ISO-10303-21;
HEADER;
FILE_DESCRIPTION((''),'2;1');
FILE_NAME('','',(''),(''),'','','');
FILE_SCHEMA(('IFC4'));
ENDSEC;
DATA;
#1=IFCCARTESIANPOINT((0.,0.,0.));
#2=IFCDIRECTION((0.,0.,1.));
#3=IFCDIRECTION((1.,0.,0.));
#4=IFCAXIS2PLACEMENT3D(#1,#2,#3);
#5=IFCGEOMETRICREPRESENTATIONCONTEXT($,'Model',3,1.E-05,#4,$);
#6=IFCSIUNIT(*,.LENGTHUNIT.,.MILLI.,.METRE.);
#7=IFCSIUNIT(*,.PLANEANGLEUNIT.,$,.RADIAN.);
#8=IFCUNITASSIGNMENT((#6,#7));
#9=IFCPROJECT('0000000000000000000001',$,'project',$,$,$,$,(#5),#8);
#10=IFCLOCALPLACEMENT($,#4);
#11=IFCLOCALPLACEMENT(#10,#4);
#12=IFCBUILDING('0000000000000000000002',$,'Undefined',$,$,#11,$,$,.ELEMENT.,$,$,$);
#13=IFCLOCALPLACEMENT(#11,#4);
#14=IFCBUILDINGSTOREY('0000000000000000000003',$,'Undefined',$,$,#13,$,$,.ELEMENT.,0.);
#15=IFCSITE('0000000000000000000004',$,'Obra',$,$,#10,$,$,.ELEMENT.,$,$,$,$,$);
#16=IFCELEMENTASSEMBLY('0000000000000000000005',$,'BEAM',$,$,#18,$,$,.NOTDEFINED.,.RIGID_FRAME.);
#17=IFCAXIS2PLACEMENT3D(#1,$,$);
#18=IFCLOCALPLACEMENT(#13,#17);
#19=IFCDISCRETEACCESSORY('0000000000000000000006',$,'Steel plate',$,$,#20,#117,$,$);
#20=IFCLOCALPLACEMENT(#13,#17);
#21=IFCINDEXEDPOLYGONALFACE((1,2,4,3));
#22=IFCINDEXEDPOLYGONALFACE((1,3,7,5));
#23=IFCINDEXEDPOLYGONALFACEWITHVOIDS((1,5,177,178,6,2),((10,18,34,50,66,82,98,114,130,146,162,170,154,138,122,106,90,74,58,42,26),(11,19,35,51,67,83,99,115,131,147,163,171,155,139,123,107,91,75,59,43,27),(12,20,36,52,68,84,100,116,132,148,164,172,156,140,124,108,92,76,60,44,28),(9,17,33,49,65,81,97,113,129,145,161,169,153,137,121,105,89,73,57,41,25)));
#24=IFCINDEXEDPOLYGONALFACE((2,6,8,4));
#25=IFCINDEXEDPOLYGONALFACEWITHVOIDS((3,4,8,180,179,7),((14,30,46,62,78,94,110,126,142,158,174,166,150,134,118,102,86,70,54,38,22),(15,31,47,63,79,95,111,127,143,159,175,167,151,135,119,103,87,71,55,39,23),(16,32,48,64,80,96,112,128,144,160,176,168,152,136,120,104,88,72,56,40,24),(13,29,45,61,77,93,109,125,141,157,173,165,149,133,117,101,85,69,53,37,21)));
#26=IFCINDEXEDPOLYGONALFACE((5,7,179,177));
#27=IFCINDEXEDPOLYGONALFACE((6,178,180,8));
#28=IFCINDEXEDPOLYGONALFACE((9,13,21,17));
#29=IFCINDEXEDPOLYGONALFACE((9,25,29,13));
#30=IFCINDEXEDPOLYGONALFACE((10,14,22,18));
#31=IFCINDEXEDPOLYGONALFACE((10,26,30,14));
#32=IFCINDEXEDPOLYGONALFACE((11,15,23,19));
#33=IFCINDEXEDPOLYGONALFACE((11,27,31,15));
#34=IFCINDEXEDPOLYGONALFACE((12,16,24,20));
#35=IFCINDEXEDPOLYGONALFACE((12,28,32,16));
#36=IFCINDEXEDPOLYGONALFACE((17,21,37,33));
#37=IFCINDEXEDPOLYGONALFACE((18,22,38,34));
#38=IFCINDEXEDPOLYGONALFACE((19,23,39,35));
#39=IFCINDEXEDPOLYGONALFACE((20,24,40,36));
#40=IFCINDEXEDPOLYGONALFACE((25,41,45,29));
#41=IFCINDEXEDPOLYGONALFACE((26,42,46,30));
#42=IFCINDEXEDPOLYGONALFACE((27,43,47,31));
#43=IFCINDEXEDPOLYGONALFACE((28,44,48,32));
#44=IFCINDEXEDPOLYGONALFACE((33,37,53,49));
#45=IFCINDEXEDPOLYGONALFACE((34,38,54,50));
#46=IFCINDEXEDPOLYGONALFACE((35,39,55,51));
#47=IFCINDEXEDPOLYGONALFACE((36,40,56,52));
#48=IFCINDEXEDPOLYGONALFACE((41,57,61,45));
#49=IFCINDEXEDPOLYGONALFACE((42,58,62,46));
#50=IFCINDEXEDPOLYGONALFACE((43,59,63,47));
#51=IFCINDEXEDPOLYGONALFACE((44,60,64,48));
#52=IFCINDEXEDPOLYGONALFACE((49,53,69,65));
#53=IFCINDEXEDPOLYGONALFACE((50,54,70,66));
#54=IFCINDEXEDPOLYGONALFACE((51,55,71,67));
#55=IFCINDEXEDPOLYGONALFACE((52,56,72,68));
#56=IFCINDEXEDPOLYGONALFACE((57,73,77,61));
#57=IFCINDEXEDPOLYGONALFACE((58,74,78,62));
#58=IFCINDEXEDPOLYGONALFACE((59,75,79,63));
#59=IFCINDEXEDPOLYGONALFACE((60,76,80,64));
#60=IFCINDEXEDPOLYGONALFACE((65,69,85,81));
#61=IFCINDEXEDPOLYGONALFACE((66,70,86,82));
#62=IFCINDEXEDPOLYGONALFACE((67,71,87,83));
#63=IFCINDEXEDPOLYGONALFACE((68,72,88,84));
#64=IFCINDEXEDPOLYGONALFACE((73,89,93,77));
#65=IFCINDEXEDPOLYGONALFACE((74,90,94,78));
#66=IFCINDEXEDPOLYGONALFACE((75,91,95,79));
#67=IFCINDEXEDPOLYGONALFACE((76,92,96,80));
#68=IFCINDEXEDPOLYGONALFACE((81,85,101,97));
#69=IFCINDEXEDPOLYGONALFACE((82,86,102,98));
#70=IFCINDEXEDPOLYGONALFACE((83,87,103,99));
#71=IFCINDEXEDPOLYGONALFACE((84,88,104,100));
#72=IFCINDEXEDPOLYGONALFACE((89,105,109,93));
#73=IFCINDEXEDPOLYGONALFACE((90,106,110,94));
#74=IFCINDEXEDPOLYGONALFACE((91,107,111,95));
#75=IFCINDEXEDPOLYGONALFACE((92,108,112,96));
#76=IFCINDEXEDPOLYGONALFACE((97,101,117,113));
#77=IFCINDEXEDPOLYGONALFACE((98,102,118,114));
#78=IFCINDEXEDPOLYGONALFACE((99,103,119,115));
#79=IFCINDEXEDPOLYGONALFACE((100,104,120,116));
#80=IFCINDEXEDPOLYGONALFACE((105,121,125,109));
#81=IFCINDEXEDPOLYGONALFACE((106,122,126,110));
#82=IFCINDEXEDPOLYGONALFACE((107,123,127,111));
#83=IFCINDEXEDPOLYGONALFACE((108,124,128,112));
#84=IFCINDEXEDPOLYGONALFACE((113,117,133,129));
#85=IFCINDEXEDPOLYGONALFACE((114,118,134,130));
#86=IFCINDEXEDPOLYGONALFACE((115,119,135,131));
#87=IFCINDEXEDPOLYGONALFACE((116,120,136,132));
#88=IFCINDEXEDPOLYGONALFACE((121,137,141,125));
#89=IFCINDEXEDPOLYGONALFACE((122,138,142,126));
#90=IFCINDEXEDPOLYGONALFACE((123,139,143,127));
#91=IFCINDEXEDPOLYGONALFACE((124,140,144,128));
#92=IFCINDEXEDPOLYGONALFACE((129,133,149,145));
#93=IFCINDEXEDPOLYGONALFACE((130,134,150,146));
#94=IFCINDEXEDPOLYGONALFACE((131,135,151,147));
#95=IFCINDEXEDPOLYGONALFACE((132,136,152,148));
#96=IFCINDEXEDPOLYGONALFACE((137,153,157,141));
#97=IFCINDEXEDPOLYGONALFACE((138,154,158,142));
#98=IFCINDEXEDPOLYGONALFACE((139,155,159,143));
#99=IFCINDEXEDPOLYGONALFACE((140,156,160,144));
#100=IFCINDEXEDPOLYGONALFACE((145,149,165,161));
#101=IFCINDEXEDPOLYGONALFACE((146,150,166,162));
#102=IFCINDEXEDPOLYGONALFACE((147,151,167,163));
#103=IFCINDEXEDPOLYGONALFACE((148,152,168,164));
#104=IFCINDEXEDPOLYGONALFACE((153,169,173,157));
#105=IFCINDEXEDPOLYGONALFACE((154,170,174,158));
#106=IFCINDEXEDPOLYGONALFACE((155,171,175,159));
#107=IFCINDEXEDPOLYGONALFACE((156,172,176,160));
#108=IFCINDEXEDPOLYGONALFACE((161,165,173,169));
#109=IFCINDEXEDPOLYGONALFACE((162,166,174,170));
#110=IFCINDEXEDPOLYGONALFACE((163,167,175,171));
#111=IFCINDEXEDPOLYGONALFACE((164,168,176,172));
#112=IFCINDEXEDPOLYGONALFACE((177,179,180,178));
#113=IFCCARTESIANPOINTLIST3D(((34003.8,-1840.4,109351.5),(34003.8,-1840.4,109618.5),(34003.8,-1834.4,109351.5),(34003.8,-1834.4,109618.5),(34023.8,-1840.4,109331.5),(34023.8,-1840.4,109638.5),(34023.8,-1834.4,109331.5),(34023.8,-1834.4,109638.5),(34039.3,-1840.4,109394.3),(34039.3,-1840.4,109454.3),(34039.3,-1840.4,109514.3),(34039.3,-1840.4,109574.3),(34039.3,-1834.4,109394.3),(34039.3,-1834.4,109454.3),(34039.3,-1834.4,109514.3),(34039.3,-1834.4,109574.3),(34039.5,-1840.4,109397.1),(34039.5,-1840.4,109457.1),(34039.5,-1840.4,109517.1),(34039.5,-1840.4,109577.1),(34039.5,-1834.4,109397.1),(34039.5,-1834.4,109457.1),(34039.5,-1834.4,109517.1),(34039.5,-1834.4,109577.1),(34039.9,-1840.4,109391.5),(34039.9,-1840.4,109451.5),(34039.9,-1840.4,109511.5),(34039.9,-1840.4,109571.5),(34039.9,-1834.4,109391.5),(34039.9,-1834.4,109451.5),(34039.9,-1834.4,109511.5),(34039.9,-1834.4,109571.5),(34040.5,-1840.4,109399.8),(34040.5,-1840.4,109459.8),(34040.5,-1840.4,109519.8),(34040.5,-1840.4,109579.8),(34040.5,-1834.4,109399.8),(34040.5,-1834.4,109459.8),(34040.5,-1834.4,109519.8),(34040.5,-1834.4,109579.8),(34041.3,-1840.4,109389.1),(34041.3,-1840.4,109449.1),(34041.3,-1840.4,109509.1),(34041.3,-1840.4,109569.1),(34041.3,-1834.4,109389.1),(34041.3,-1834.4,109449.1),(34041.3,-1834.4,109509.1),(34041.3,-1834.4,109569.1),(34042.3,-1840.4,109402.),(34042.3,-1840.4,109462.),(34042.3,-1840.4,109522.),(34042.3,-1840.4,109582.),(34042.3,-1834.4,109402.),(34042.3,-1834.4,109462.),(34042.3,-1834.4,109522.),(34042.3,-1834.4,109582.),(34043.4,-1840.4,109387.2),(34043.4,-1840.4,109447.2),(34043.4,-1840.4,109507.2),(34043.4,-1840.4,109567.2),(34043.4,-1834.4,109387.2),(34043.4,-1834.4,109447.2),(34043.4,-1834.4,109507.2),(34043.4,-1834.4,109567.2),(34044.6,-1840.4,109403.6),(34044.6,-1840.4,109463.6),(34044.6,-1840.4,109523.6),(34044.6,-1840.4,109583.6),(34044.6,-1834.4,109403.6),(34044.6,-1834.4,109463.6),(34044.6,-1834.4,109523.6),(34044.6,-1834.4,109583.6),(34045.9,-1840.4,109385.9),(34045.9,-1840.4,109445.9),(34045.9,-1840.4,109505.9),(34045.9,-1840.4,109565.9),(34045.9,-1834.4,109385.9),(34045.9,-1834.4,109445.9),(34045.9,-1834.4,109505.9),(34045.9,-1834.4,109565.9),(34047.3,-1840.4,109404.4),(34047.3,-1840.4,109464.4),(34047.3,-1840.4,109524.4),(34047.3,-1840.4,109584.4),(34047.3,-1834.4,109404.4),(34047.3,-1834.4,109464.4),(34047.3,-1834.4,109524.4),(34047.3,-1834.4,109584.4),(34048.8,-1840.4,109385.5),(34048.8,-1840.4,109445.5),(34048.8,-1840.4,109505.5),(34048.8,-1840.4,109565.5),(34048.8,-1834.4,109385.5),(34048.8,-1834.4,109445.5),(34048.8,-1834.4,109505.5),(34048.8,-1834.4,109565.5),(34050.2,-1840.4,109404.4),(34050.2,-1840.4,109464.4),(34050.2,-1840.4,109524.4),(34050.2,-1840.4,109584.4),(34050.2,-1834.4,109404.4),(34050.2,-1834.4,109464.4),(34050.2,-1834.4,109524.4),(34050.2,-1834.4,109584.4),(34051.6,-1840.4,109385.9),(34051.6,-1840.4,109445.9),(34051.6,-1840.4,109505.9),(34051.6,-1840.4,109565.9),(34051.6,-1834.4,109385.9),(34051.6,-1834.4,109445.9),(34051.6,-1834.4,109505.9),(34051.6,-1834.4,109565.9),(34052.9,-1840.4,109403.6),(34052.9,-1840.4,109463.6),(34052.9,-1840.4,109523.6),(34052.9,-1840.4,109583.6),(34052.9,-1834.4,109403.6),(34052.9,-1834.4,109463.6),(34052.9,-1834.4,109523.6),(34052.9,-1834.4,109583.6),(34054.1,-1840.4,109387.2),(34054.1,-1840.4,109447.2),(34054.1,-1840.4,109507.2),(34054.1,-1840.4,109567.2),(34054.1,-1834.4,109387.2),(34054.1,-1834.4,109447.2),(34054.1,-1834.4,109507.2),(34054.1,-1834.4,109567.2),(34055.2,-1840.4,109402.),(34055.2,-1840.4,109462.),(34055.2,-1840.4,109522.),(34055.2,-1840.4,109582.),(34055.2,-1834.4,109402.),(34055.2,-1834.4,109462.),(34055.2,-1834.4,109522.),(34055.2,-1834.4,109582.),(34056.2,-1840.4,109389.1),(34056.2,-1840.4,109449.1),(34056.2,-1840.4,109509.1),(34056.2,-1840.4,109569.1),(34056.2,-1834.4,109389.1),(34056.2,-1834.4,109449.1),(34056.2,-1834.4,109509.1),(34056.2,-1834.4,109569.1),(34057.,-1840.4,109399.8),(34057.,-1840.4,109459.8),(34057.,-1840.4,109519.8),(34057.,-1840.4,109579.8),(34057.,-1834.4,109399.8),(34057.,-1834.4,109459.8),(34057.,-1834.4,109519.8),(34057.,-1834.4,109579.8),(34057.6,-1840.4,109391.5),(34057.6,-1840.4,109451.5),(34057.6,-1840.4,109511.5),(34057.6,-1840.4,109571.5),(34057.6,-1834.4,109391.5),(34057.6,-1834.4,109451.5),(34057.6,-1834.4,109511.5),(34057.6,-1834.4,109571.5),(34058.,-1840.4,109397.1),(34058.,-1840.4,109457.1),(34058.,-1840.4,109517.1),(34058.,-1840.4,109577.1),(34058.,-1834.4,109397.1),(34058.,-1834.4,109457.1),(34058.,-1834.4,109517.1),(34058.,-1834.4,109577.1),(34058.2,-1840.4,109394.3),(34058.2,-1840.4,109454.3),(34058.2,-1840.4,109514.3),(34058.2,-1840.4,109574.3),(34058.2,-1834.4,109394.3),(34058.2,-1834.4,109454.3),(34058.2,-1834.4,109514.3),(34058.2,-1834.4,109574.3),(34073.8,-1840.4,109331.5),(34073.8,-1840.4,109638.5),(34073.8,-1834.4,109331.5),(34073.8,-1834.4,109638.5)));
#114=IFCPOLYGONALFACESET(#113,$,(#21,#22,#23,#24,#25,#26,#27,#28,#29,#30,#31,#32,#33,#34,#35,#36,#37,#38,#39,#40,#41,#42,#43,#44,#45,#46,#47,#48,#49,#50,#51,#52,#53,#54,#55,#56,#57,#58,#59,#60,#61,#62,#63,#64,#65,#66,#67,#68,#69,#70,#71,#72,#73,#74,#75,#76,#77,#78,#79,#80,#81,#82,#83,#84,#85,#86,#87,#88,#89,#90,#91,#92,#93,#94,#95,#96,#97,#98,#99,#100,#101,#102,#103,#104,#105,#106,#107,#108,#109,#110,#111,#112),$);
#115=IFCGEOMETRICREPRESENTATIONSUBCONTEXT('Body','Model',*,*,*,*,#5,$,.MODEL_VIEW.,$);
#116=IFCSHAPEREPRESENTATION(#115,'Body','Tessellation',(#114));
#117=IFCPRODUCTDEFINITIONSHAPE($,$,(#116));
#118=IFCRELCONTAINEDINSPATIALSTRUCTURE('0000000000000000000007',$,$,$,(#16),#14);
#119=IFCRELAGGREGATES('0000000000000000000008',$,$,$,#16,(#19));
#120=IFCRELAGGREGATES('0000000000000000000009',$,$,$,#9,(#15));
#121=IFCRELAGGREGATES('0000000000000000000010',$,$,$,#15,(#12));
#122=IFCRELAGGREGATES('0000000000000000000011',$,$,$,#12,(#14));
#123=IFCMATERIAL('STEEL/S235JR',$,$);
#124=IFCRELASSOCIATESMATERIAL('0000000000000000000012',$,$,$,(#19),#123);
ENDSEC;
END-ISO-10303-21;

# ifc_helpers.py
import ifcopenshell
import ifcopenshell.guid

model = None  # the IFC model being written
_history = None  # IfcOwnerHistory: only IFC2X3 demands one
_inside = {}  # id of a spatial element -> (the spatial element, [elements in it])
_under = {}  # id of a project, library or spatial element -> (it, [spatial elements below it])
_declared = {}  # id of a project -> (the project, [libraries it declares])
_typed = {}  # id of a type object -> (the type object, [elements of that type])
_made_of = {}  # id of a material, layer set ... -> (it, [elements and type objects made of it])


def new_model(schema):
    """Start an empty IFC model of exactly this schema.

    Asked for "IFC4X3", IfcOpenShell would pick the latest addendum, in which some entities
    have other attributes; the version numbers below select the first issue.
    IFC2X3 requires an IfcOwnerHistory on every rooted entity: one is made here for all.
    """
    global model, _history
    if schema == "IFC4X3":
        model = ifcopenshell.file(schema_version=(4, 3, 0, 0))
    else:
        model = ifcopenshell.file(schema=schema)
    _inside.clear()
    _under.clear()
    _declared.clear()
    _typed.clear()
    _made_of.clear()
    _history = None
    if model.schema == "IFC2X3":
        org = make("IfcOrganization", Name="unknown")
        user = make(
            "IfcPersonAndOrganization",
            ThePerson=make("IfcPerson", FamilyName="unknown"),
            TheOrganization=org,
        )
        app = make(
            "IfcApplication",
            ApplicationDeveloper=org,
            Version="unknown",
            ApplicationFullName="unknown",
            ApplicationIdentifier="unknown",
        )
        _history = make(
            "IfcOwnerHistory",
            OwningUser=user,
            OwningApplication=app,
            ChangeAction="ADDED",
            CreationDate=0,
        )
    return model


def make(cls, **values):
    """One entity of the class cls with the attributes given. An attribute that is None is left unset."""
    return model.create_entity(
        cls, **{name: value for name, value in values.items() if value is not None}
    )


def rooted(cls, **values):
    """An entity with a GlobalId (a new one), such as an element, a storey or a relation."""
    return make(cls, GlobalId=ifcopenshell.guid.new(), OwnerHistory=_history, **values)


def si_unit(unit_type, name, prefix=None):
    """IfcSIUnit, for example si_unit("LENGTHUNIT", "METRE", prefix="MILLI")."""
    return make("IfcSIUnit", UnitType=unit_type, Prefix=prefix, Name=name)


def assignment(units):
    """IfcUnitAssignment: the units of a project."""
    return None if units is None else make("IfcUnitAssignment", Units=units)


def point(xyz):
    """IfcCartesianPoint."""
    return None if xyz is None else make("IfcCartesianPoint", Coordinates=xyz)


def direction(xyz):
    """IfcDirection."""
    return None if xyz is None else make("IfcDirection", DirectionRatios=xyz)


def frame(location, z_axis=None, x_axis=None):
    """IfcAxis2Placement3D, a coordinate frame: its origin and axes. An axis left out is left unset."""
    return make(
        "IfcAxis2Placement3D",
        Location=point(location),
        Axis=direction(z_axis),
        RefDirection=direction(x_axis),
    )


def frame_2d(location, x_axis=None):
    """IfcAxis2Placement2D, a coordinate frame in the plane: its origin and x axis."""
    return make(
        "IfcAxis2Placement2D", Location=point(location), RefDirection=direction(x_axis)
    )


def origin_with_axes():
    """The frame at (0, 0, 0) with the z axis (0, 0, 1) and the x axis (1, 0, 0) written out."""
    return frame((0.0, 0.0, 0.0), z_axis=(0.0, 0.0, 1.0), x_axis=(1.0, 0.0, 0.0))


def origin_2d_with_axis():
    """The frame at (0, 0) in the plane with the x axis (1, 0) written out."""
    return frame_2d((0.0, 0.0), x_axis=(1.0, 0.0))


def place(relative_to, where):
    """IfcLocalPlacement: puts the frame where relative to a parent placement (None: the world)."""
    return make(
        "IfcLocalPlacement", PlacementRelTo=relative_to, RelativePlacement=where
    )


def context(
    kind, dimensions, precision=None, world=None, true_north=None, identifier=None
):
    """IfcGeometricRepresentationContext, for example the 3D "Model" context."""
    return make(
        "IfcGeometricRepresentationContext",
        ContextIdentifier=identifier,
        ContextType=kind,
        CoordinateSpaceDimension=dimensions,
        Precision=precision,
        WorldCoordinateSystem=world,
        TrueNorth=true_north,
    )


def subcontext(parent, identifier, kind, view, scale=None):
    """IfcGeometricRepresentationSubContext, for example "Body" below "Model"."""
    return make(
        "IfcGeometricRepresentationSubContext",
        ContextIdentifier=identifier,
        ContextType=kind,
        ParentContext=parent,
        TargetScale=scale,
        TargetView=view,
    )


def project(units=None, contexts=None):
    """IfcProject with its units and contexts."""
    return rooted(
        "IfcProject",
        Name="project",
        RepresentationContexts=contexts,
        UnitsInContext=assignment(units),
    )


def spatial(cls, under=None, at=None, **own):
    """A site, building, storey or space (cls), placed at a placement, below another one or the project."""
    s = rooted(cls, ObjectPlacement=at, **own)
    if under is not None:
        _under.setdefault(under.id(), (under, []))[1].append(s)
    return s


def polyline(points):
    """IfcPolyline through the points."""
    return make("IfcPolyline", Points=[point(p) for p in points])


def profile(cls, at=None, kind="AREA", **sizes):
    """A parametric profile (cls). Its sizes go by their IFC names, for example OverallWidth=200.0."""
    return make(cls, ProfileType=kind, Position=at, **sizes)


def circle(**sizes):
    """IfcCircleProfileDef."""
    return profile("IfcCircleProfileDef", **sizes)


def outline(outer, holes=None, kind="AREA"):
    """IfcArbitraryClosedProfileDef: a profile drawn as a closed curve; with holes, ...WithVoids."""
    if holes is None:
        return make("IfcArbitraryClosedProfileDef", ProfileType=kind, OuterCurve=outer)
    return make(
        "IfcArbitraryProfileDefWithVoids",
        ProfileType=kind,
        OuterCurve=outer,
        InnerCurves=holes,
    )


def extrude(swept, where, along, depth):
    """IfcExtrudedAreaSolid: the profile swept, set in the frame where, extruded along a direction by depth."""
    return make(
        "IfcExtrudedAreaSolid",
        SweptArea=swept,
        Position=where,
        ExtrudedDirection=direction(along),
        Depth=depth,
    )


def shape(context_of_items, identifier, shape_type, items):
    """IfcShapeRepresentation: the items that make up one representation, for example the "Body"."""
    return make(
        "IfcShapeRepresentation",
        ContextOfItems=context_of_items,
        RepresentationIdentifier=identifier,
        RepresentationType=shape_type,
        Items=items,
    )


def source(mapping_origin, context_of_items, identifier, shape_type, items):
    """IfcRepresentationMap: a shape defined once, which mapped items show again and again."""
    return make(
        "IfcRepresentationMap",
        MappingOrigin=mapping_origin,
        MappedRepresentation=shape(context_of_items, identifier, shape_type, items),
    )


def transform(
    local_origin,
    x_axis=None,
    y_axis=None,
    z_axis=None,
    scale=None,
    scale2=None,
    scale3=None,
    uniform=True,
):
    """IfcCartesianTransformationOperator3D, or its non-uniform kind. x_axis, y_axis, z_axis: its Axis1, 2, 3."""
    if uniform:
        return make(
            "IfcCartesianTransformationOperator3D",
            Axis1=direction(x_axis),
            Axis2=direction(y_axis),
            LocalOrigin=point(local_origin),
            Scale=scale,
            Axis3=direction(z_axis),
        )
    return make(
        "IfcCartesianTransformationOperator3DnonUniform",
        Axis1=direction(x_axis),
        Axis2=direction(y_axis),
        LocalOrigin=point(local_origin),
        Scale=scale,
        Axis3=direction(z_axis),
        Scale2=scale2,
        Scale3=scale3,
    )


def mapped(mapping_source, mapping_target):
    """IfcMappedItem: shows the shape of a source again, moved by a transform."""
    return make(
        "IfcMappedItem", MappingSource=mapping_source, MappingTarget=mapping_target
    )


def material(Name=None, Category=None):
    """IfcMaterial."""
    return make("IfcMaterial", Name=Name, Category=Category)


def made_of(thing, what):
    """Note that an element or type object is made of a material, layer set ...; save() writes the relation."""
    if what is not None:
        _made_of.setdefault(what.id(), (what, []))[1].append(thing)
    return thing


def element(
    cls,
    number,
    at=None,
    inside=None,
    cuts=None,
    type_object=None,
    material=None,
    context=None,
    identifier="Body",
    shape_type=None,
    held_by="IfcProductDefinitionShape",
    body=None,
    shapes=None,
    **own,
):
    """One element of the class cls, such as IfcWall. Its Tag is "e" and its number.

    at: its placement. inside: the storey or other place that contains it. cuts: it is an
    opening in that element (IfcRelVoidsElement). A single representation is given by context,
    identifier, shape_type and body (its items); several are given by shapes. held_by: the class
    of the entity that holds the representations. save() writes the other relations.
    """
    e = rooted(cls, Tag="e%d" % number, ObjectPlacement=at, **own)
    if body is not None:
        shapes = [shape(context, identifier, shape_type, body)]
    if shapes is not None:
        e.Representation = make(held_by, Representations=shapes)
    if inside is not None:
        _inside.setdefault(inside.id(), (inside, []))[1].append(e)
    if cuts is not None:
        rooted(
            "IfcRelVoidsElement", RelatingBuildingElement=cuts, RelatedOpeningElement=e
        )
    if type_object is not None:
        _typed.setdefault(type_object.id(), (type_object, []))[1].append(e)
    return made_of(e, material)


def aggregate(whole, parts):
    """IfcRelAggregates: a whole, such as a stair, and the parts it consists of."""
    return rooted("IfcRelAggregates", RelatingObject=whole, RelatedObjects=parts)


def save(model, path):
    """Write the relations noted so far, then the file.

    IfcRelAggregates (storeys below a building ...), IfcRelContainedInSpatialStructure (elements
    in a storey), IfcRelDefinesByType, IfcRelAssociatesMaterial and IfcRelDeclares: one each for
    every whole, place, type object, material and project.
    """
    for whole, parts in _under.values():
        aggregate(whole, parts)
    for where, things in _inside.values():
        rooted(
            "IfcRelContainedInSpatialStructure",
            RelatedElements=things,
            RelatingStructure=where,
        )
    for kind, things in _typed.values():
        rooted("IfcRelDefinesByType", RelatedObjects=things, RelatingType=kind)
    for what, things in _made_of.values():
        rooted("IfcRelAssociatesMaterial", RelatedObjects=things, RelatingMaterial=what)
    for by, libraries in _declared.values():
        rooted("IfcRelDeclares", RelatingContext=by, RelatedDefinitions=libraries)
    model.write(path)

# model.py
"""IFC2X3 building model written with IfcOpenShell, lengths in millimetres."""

from ifc_helpers import new_model, si_unit, frame, origin_with_axes, origin_2d_with_axis, place, context, subcontext, project, spatial, polyline, circle, outline, extrude, source, transform, mapped, material, element, aggregate, save


model = new_model("IFC2X3")

# Units and contexts
model_context = context("Model", 3, precision=1e-05, world=origin_with_axes())
body_context = subcontext(model_context, "Body", "Model", "MODEL_VIEW")
ifc_project = project(units=[si_unit("LENGTHUNIT", "METRE", prefix="MILLI"), si_unit("PLANEANGLEUNIT", "RADIAN")], contexts=[model_context])

# Site, building, storey
site_placement = place(None, origin_with_axes())
site = spatial("IfcSite", under=ifc_project, at=site_placement, Name="Obra", CompositionType="ELEMENT")
building_placement = place(site_placement, origin_with_axes())
building = spatial("IfcBuilding", under=site, at=building_placement, Name="Undefined", CompositionType="ELEMENT")
storey_placement = place(building_placement, origin_with_axes())
storey = spatial("IfcBuildingStorey", under=building, at=storey_placement, Name="Undefined", CompositionType="ELEMENT", Elevation=0.0)

# Element assembly, discrete accessory, opening
ifc_material = material(Name="STEEL/S235JR")
shared_shape = source(origin_with_axes(), body_context, "Body", "SweptSolid", [
    extrude(circle(Radius=9.5, at=origin_2d_with_axis()), frame((0.0, -9.8, 0.0), z_axis=(0.0, 1.0, 0.0), x_axis=(1.0, 0.0, 0.0)), (0.0, 0.0, 1.0), 6.2),
])
assembly_1_placement = place(storey_placement, origin_with_axes())
assembly_1 = element("IfcElementAssembly", 1, at=assembly_1_placement, inside=storey, Name="BEAM", AssemblyPlace="NOTDEFINED", PredefinedType="RIGID_FRAME")
discrete_accessory_1_placement = place(assembly_1_placement, frame((34073.8, -1837.4, 109331.5), z_axis=(0.000001, 1.0, 0.0), x_axis=(-1.0, 0.000001, 0.0)))
discrete_accessory_1 = element("IfcDiscreteAccessory", 2, at=discrete_accessory_1_placement, material=ifc_material, Name="Steel plate", context=body_context, shape_type="SweptSolid", body=[
    extrude(outline(polyline([(0.0, 0.0), (50.0, 0.0), (70.0, 20.0), (70.0, 287.0), (50.0, 307.0), (0.0, 307.0), (0.0, 0.0)])), frame((0.0, 0.0, -3.0), z_axis=(0.0, 0.0, 1.0), x_axis=(1.0, 0.0, 0.0)), (0.0, 0.0, 1.0), 6.0),
])
opening_1_placement = place(assembly_1_placement, frame((34013.8, -1830.7, 109650.0), z_axis=(1.0, -0.000001, 0.0), x_axis=(0.0, 0.0, -1.0)))
element("IfcOpeningElement", 3, at=opening_1_placement, cuts=discrete_accessory_1, ObjectType="Opening", context=body_context, shape_type="MappedRepresentation", body=[
    mapped(shared_shape, transform((75.0, 0.0, 35.0))),
    mapped(shared_shape, transform((135.0, 0.0, 35.0))),
    mapped(shared_shape, transform((195.0, 0.0, 35.0))),
    mapped(shared_shape, transform((255.0, 0.0, 35.0))),
])
aggregate(assembly_1, [discrete_accessory_1])

save(model, "model.ifc")
